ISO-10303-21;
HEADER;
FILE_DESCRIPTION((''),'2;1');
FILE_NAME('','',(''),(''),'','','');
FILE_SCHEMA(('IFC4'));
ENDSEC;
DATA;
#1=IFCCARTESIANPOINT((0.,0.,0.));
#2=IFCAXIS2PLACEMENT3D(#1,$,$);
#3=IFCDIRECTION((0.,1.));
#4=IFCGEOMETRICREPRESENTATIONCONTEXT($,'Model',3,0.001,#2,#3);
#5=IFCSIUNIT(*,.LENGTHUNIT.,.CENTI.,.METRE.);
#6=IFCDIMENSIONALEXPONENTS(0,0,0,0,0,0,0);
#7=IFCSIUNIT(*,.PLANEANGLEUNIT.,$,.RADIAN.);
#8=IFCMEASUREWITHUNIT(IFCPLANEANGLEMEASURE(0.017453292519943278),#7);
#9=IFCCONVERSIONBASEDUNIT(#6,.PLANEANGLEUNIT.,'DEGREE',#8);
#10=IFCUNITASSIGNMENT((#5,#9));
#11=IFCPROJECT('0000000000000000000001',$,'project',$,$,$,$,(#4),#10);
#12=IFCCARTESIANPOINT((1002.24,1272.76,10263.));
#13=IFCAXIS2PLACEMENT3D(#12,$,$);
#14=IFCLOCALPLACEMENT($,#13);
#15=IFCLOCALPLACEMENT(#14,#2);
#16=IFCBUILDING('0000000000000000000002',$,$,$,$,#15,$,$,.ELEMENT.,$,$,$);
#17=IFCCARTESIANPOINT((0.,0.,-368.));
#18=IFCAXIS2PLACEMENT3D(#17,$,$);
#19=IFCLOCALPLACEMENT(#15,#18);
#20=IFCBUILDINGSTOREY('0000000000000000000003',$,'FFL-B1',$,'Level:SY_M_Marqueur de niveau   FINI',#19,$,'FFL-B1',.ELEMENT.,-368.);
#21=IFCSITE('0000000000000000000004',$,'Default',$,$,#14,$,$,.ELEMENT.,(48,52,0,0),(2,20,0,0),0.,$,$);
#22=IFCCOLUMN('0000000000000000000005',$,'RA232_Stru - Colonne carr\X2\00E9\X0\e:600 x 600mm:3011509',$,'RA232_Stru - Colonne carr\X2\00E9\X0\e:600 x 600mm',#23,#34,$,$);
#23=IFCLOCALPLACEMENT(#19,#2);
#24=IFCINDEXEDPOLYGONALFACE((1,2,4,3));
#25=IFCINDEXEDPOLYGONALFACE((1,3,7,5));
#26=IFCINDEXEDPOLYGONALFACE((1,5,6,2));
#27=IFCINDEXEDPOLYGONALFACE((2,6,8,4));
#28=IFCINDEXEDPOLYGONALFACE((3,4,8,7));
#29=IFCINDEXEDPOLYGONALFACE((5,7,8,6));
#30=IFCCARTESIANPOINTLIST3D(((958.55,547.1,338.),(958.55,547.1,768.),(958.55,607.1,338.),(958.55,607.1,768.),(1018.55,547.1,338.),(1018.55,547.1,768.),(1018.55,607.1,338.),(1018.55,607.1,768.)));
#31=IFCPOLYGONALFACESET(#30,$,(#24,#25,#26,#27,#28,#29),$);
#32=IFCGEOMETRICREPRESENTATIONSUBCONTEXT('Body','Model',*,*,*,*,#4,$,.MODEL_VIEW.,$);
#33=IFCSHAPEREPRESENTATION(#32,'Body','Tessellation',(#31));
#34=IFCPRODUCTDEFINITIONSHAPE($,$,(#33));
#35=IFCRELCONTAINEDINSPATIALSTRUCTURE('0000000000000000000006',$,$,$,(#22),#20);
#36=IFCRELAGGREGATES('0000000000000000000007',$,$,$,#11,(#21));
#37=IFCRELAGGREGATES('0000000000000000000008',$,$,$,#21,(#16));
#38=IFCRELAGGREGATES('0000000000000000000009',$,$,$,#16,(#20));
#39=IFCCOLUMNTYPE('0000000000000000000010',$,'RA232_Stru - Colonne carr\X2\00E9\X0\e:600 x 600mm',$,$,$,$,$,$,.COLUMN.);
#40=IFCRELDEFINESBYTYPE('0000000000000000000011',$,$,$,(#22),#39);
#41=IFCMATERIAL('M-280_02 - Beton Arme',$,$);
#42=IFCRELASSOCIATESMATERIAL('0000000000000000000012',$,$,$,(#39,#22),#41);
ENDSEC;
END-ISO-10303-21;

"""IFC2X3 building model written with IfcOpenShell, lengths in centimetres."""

from ifc_helpers import new_model, entity, si_unit, converted_unit, direction, frame, frame_2d, origin, place, context, subcontext, project, spatial, rectangle, extrude, source, transform, mapped, material, type_object, type_shapes, element, save


model = new_model("IFC2X3")

# Units and contexts
model_context = context("Model", 3, precision=0.001, world=origin(), true_north=direction((0.0, 1.0)))
body_context = subcontext(model_context, "Body", "Model", "MODEL_VIEW")
ifc_project = project(units=[si_unit("LENGTHUNIT", "METRE", prefix="CENTI"), converted_unit("PLANEANGLEUNIT", "DEGREE", entity("IfcPlaneAngleMeasure", 0.017453292519943278), si_unit("PLANEANGLEUNIT", "RADIAN"), dimensions=[0, 0, 0, 0, 0, 0, 0])], contexts=[model_context])

# Site, building, storey
site_placement = place(None, frame((1002.24, 1272.76, 10263.0)))
site = spatial("IfcSite", under=ifc_project, at=site_placement, Name="Default", CompositionType="ELEMENT", RefLatitude=(48, 52, 0, 0), RefLongitude=(2, 20, 0, 0), RefElevation=0.0)
building_placement = place(site_placement, origin())
building = spatial("IfcBuilding", under=site, at=building_placement, CompositionType="ELEMENT")
storey_placement = place(building_placement, frame((0.0, 0.0, -368.0)))
storey = spatial("IfcBuildingStorey", under=building, at=storey_placement, Name="FFL-B1", ObjectType="Level:SY_M_Marqueur de niveau   FINI", LongName="FFL-B1", CompositionType="ELEMENT", Elevation=-368.0)

# Column
ifc_material_1 = material(Name="M-280_02 - Beton Arme")
column_type_1 = type_object("IfcColumnType", Name="RA232_Stru - Colonne carrée:600 x 600mm", PredefinedType="COLUMN", material=ifc_material_1)
shared_shape_1 = source(origin(), body_context, "Body", "SweptSolid", [
    extrude(rectangle(XDim=60.0, YDim=60.0, at=frame_2d((0.0, 0.0), x_axis=(1.0, 0.0))), frame((988.55, 577.1, -30.0), z_axis=(0.0, 0.0, 1.0), x_axis=(-1.0, 0.0, 0.0)), (0.0, 0.0, 1.0), 430.0),
])
type_shapes(column_type_1, [shared_shape_1])
column_1_placement = place(storey_placement, frame((0.0, 0.0, 368.0)))
element("IfcColumn", 1, at=column_1_placement, inside=storey, type_object=column_type_1, material=ifc_material_1, Name="RA232_Stru - Colonne carrée:600 x 600mm:3011509", ObjectType="RA232_Stru - Colonne carrée:600 x 600mm", context=body_context, shape_type="MappedRepresentation", body=[
    mapped(shared_shape_1, transform((0.0, 0.0, 0.0), scale=1.0)),
])

save(model, "model.ifc")
